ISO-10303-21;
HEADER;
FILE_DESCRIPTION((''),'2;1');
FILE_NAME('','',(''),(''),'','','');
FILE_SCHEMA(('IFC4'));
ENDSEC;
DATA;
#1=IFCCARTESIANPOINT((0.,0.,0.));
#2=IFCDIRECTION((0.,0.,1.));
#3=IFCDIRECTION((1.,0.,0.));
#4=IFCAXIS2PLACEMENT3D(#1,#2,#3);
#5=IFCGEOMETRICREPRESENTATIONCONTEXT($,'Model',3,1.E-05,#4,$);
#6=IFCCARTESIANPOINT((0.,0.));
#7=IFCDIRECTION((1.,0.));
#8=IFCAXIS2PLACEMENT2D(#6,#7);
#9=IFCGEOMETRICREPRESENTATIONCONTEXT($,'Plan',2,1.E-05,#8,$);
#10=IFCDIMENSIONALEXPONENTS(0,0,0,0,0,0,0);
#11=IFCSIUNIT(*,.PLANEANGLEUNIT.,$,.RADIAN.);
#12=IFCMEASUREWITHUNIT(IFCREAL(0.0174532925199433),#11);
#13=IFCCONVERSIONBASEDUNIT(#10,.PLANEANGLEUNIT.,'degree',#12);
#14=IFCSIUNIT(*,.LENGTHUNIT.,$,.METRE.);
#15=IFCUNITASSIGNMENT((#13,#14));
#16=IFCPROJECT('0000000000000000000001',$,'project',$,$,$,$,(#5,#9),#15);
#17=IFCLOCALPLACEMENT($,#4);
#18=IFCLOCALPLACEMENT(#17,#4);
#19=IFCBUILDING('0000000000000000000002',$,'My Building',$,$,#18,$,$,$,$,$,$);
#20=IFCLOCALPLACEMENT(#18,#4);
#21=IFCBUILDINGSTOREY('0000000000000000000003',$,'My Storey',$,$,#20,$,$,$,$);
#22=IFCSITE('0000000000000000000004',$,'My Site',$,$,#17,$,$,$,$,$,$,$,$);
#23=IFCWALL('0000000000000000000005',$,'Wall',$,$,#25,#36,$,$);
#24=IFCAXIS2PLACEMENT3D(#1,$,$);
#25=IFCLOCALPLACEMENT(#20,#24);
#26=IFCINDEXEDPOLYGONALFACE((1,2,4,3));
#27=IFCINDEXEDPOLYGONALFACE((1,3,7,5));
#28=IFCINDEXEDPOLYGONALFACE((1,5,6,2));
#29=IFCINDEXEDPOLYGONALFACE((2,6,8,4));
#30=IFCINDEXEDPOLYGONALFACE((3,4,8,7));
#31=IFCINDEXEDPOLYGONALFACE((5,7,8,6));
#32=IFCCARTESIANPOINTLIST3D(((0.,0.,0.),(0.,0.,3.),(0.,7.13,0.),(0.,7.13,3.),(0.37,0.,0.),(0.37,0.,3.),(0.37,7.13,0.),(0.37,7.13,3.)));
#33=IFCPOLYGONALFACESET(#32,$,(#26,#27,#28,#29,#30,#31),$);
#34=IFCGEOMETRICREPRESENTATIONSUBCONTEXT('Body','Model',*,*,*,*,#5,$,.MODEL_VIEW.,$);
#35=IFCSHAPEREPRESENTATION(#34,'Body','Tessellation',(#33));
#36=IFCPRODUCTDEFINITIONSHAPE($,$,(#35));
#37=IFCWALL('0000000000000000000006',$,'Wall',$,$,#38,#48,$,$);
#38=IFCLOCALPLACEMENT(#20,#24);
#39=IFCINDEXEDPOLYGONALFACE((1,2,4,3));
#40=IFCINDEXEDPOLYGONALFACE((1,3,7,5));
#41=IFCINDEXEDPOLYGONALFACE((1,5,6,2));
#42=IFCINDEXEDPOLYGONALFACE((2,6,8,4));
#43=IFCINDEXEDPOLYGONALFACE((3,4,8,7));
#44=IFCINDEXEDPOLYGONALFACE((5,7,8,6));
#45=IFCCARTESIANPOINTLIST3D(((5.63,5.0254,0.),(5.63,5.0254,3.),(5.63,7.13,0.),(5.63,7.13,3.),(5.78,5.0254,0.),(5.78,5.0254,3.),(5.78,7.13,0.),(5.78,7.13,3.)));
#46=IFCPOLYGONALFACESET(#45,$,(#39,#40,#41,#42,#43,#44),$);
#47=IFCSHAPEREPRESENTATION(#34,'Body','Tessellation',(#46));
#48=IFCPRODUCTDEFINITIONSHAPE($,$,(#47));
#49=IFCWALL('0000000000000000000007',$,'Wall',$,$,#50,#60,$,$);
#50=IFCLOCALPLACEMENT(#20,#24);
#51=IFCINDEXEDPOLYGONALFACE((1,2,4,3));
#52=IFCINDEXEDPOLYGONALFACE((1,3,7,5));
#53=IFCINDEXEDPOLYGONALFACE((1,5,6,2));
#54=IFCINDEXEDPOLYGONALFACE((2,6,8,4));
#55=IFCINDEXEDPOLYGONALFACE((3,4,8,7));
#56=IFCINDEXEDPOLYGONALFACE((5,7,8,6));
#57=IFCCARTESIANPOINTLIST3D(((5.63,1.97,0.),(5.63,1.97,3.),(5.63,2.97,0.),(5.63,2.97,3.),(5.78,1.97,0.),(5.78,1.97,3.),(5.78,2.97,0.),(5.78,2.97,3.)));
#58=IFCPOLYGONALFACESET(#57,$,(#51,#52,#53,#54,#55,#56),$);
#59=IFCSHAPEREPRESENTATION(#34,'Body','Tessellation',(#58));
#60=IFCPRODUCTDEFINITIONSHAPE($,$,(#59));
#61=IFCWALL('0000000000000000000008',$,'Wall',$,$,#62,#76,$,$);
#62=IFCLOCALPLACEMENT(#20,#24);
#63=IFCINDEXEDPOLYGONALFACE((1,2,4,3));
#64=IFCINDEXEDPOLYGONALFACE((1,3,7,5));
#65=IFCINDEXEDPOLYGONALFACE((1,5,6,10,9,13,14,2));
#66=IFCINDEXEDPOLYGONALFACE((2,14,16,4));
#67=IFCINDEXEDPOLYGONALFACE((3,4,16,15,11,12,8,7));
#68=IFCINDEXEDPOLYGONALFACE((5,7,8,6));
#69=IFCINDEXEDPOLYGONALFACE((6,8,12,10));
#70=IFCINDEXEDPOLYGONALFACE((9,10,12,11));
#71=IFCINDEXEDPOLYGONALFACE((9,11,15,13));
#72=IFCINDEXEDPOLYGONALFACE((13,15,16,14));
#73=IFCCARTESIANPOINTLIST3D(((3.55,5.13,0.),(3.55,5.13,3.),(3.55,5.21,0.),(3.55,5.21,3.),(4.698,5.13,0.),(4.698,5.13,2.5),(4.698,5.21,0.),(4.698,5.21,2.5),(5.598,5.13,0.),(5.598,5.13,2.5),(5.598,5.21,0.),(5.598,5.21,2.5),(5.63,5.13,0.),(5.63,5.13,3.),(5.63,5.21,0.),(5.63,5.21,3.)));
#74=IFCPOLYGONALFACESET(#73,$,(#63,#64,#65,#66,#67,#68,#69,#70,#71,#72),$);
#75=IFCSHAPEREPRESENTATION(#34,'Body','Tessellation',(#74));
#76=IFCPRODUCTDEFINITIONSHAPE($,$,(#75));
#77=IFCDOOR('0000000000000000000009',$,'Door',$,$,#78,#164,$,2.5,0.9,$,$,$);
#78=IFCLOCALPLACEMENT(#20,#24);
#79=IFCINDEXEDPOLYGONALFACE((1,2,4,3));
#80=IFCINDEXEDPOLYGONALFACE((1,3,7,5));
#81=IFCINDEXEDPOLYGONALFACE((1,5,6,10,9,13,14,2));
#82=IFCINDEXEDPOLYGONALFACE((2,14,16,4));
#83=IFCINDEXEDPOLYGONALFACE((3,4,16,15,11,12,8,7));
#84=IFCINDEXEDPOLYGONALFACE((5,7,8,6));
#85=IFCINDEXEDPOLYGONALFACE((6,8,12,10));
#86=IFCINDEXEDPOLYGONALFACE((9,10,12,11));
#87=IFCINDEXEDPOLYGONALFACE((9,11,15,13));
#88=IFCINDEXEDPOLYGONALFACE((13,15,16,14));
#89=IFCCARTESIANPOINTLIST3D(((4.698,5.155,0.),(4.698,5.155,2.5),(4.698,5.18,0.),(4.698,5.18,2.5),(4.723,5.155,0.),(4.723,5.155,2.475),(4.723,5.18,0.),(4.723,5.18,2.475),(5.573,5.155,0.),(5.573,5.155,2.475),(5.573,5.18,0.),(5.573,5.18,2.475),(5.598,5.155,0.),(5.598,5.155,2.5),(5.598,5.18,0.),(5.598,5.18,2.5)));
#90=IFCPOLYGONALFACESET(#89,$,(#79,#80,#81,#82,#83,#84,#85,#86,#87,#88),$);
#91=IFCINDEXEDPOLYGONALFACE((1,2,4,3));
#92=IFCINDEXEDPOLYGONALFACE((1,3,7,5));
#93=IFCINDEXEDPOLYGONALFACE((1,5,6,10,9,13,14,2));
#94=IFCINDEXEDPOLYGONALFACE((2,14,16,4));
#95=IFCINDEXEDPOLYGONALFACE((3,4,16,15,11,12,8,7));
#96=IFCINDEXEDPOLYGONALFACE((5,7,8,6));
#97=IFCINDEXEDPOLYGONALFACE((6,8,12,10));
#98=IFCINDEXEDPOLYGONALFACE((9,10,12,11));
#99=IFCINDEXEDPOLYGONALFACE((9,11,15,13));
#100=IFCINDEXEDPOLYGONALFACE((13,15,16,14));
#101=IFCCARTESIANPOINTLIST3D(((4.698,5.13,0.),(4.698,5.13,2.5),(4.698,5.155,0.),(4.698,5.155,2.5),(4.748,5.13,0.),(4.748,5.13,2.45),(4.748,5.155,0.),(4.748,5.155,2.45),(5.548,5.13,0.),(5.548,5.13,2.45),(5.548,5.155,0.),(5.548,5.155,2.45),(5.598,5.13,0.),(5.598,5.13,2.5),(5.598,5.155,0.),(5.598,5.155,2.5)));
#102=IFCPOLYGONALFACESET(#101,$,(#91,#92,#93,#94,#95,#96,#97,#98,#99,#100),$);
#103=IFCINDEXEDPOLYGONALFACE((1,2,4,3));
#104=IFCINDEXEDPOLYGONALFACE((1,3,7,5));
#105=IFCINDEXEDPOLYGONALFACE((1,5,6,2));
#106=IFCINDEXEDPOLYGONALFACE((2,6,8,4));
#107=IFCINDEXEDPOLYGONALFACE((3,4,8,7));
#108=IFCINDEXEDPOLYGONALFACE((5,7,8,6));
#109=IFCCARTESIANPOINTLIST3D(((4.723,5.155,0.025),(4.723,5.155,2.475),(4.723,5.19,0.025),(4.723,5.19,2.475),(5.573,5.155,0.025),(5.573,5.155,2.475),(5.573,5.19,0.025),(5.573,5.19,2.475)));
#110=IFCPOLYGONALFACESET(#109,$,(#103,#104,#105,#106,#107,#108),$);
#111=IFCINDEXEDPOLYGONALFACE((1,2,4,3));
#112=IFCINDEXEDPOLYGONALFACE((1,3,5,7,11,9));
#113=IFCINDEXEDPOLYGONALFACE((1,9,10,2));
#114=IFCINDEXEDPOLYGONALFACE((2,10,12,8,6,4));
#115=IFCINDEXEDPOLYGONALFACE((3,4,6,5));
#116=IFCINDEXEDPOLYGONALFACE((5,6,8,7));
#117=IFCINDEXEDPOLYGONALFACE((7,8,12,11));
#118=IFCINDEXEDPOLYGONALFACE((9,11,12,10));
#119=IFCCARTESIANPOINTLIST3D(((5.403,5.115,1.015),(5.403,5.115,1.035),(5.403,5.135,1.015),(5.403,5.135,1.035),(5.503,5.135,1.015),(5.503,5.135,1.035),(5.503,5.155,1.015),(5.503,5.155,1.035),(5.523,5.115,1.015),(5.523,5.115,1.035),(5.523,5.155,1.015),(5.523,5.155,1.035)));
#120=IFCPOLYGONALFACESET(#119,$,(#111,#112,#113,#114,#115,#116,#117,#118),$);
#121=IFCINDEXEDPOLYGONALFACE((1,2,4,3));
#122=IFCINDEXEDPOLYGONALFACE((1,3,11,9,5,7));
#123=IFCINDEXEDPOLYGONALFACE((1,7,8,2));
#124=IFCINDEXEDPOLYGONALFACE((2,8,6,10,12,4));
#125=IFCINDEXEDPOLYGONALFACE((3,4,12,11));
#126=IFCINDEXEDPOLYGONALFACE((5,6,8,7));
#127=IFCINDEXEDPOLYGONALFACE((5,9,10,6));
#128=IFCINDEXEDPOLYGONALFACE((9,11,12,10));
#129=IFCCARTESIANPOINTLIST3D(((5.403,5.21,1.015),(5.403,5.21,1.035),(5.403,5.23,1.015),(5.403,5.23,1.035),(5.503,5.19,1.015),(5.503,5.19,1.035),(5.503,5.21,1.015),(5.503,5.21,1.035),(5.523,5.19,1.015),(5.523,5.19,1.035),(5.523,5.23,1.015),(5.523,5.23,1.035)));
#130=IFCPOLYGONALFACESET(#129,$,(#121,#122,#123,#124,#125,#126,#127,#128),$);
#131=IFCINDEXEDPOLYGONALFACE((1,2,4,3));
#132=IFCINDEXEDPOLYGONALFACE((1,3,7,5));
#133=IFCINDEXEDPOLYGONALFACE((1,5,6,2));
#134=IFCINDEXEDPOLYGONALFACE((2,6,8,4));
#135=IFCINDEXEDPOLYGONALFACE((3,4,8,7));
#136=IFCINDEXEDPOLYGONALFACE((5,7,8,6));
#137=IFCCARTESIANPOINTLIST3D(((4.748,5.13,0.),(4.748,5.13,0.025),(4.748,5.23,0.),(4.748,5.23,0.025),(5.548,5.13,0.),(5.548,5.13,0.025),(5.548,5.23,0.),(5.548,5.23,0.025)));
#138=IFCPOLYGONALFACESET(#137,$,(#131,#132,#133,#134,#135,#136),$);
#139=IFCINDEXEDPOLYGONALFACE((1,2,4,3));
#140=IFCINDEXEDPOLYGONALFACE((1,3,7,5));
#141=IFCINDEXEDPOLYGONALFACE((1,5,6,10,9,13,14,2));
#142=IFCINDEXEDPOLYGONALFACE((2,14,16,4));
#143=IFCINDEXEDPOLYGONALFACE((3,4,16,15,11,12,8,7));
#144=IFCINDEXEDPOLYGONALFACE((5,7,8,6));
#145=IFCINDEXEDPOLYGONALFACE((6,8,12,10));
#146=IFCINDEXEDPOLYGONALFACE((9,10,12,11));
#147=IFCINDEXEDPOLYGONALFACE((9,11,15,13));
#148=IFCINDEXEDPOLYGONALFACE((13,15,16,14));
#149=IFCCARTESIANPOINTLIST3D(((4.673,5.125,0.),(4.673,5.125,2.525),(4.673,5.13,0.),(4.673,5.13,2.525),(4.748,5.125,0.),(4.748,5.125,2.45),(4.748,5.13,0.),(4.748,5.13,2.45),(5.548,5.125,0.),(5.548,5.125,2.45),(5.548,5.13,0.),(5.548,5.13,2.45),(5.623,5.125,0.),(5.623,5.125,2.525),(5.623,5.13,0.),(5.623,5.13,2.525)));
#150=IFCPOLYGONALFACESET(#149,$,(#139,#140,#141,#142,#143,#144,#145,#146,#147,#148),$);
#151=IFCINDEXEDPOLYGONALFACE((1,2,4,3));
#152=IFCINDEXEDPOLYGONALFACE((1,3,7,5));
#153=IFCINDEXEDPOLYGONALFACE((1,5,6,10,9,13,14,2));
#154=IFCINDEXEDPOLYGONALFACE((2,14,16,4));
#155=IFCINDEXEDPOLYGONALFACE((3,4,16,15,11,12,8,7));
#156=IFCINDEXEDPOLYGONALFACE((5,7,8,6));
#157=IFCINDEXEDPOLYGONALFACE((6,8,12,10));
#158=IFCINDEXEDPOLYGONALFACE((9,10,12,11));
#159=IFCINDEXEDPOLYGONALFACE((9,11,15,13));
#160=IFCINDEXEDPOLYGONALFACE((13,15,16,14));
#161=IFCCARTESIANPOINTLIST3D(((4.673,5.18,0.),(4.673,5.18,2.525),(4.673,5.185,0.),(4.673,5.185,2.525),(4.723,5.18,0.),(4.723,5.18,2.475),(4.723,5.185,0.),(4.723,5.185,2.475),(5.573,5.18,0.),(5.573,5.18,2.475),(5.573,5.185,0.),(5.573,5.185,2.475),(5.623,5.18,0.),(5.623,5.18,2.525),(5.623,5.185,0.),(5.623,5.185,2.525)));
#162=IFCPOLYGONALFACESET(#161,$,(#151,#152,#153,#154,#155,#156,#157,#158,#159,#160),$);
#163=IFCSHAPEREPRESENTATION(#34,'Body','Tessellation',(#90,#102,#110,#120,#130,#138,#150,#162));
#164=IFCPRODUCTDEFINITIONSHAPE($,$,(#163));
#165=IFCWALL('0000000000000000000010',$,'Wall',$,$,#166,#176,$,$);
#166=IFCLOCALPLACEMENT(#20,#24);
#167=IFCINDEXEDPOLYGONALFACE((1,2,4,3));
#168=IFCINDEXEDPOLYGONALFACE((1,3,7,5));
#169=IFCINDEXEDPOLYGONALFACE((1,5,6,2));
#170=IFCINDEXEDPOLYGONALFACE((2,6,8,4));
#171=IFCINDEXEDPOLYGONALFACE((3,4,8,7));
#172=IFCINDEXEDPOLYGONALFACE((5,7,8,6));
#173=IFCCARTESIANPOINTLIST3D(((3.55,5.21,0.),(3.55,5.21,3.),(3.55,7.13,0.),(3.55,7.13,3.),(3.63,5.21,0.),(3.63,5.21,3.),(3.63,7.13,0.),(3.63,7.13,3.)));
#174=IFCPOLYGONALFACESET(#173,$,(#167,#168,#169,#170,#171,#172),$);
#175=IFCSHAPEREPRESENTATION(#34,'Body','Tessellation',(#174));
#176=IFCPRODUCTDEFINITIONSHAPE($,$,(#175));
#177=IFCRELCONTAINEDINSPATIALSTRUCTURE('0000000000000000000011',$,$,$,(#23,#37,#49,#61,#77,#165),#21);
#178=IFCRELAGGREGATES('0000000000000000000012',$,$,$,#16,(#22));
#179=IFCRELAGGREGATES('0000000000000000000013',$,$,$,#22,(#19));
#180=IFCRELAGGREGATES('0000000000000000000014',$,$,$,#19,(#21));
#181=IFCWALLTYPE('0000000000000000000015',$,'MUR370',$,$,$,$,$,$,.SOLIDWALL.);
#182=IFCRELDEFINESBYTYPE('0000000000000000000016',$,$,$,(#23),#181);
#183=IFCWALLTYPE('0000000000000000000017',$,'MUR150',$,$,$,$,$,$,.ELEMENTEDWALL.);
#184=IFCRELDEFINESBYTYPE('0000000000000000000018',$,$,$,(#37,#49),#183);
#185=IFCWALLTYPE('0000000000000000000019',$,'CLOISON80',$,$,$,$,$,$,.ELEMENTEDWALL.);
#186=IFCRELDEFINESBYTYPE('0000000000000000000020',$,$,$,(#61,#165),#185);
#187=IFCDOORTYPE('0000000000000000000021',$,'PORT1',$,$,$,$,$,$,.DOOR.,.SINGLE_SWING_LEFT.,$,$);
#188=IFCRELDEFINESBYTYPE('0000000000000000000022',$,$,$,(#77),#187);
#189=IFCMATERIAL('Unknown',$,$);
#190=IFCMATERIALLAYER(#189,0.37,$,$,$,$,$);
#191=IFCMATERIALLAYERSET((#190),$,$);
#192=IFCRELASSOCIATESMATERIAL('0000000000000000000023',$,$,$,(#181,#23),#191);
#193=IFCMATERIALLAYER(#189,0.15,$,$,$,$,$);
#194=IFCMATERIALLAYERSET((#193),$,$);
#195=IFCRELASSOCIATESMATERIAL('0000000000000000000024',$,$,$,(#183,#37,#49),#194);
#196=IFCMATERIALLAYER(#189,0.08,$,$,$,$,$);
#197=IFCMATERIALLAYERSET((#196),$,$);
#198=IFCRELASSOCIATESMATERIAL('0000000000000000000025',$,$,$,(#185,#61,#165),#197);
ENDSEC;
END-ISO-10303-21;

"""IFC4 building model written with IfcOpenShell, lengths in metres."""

from ifc_helpers import new_model, entity, si_unit, converted_unit, frame, origin_with_axes, origin_2d_with_axis, place, context, subcontext, project, spatial, line, indexed_curve, outline, extrude, shape, source, transform, mapped, material, layer, layer_set, layer_usage, type_object, type_shapes, element, fill, save


model = new_model("IFC4")

# Units and contexts
model_context = context("Model", 3, precision=1e-05, world=origin_with_axes())
plan_context = context("Plan", 2, precision=1e-05, world=origin_2d_with_axis())
body_context_1 = subcontext(model_context, "Body", "Model", "MODEL_VIEW")
body_context_2 = subcontext(plan_context, "Body", "Plan", "PLAN_VIEW")
ifc_project = project(units=[converted_unit("PLANEANGLEUNIT", "degree", entity("IfcReal", 0.0174532925199433), si_unit("PLANEANGLEUNIT", "RADIAN"), dimensions=[0, 0, 0, 0, 0, 0, 0]), si_unit("LENGTHUNIT", "METRE")], contexts=[model_context, plan_context])

# Site, building, storey
site_placement = place(None, origin_with_axes())
site = spatial("IfcSite", under=ifc_project, at=site_placement, Name="My Site")
building_placement = place(site_placement, origin_with_axes())
building = spatial("IfcBuilding", under=site, at=building_placement, Name="My Building")
storey_placement = place(building_placement, origin_with_axes())
storey = spatial("IfcBuildingStorey", under=building, at=storey_placement, Name="My Storey")

# Shared definitions
ifc_material = material(Name="Unknown")

# Shared definitions
ifc_layer_1 = layer(ifc_material, 0.37)
ifc_layer_set_1 = layer_set([ifc_layer_1])
wall_type_1 = type_object("IfcWallType", Name="MUR370", PredefinedType="SOLIDWALL", material=ifc_layer_set_1)

# Shared definitions
shared_shape_1 = source(origin_with_axes(), body_context_1, "Body", "SweptSolid", [
    extrude(outline(indexed_curve([(0.0, 0.0), (0.9, 0.0), (0.9, 2.5), (0.0, 2.5)], segments=[line(1, 2, 3, 4, 1)])), frame((0.0, -0.6, 0.0), z_axis=(0.0, -1.0, 0.0), x_axis=(1.0, 0.0, 0.0)), (0.0, 0.0, -1.0), 1.2),
])
door_type_1 = type_object("IfcDoorType", Name="PORT1", OperationType="SINGLE_SWING_LEFT", PredefinedType="DOOR")
shared_shape_2 = source(origin_with_axes(), body_context_1, "Body", "SweptSolid", [
    extrude(outline(indexed_curve([(0.0, 0.0), (0.0, 2.5), (0.9, 2.5), (0.9, 0.0), (0.875, 0.0), (0.875, 2.475), (0.025, 2.475), (0.025, 0.0)], segments=[line(1, 2, 3, 4, 5, 6, 7, 8, 1)])), frame((0.0, 0.025, 0.0), z_axis=(0.0, -1.0, 0.0), x_axis=(1.0, 0.0, 0.0)), (0.0, 0.0, -1.0), 0.025),
    extrude(outline(indexed_curve([(0.0, 0.0), (0.0, 2.5), (0.9, 2.5), (0.9, 0.0), (0.85, 0.0), (0.85, 2.45), (0.05, 2.45), (0.05, 0.0)], segments=[line(1, 2, 3, 4, 5, 6, 7, 8, 1)])), frame((0.0, 0.0, 0.0), z_axis=(0.0, -1.0, 0.0), x_axis=(1.0, 0.0, 0.0)), (0.0, 0.0, -1.0), 0.025),
    extrude(outline(indexed_curve([(0.0, 0.0), (0.85, 0.0), (0.85, 0.035), (0.0, 0.035)], segments=[line(1, 2, 3, 4, 1)])), frame((0.025, 0.025, 0.025), z_axis=(0.0, 0.0, 1.0), x_axis=(1.0, 0.0, 0.0)), (0.0, 0.0, 1.0), 2.45),
    extrude(outline(indexed_curve([(0.0, 0.0), (0.0, -0.04), (-0.12, -0.04), (-0.12, -0.02), (-0.02, -0.02), (-0.02, 0.0)], segments=[line(1, 2, 3, 4, 5, 6, 1)])), frame((0.825, 0.025, 1.015), z_axis=(0.0, 0.0, 1.0), x_axis=(1.0, 0.0, 0.0)), (0.0, 0.0, 1.0), 0.02),
    extrude(outline(indexed_curve([(0.0, 0.0), (0.0, 0.04), (-0.12, 0.04), (-0.12, 0.02), (-0.02, 0.02), (-0.02, 0.0)], segments=[line(1, 2, 3, 4, 5, 6, 1)])), frame((0.825, 0.06, 1.015), z_axis=(0.0, 0.0, 1.0), x_axis=(1.0, 0.0, 0.0)), (0.0, 0.0, 1.0), 0.02),
    extrude(outline(indexed_curve([(0.0, 0.0), (0.8, 0.0), (0.8, 0.1), (0.0, 0.1)], segments=[line(1, 2, 3, 4, 1)])), frame((0.05, 0.0, 0.0), z_axis=(0.0, 0.0, 1.0), x_axis=(1.0, 0.0, 0.0)), (0.0, 0.0, 1.0), 0.025),
    extrude(outline(indexed_curve([(0.0, 0.0), (0.0, 2.525), (0.95, 2.525), (0.95, 0.0), (0.875, 0.0), (0.875, 2.45), (0.075, 2.45), (0.075, 0.0)], segments=[line(1, 2, 3, 4, 5, 6, 7, 8, 1)])), frame((-0.025, -0.005, 0.0), z_axis=(0.0, -1.0, 0.0), x_axis=(1.0, 0.0, 0.0)), (0.0, 0.0, -1.0), 0.005),
    extrude(outline(indexed_curve([(0.0, 0.0), (0.0, 2.525), (0.95, 2.525), (0.95, 0.0), (0.9, 0.0), (0.9, 2.475), (0.05, 2.475), (0.05, 0.0)], segments=[line(1, 2, 3, 4, 5, 6, 7, 8, 1)])), frame((-0.025, 0.05, 0.0), z_axis=(0.0, -1.0, 0.0), x_axis=(1.0, 0.0, 0.0)), (0.0, 0.0, -1.0), 0.005),
])
shared_shape_3 = source(origin_with_axes(), body_context_2, "Body", "Curve2D", [
    entity("IfcIndexedPolyCurve", entity("IfcCartesianPointList2D", [[0.0, 0.0], [0.0, 0.05], [0.025, 0.05], [0.025, 0.025], [0.05, 0.025], [0.05, 0.0]]), [entity("IfcLineIndex", [1, 2, 3, 4, 5, 6, 1])]),
    entity("IfcIndexedPolyCurve", entity("IfcCartesianPointList2D", [[0.9, 0.0], [0.9, 0.05], [0.875, 0.05], [0.875, 0.025], [0.85, 0.025], [0.85, 0.0]]), [entity("IfcLineIndex", [1, 2, 3, 4, 5, 6, 1])]),
    entity("IfcTrimmedCurve", entity("IfcEllipse", entity("IfcAxis2Placement2D", entity("IfcCartesianPoint", [0.06, 0.05]), entity("IfcDirection", [1.0, 0.0])), 0.815, 0.85), [entity("IfcCartesianPoint", [0.875, 0.05])], [entity("IfcCartesianPoint", [0.06, 0.9])], True, "CARTESIAN"),
    entity("IfcIndexedPolyCurve", entity("IfcCartesianPointList2D", [[0.025, 0.05], [0.06, 0.05], [0.06, 0.9], [0.025, 0.9]]), [entity("IfcLineIndex", [1, 2, 3, 4, 1])]),
])
type_shapes(door_type_1, [shared_shape_2, shared_shape_3])

# Walls
ifc_layer_usage_1 = layer_usage(ifc_layer_set_1, "AXIS2", "POSITIVE", 0.0)
wall_1_placement = place(storey_placement, frame((0.0, 7.13, 0.0), z_axis=(0.0, 0.0, 1.0), x_axis=(-0.000001, -1.0, 0.0)))
element("IfcWall", 1, at=wall_1_placement, inside=storey, type_object=wall_type_1, material=ifc_layer_usage_1, Name="Wall", context=body_context_1, shape_type="SweptSolid", body=[
    extrude(outline(indexed_curve([(0.0, 0.0), (0.0, 0.37), (7.13, 0.37), (7.13, 0.0), (0.0, 0.0)], self_intersect=False)), origin_with_axes(), (0.0, 0.0, 1.0), 3.0),
])
ifc_layer_2 = layer(ifc_material, 0.15)
ifc_layer_set_2 = layer_set([ifc_layer_2])
ifc_layer_usage_2 = layer_usage(ifc_layer_set_2, "AXIS2", "POSITIVE", 0.0)
wall_type_2 = type_object("IfcWallType", Name="MUR150", PredefinedType="ELEMENTEDWALL", material=ifc_layer_set_2)
wall_2_placement = place(storey_placement, frame((5.63, 7.13, 0.0), z_axis=(0.0, 0.0, 1.0), x_axis=(0.0, -1.0, 0.0)))
element("IfcWall", 2, at=wall_2_placement, inside=storey, type_object=wall_type_2, material=ifc_layer_usage_2, Name="Wall", context=body_context_1, shape_type="SweptSolid", body=[
    extrude(outline(indexed_curve([(0.0, 0.0), (0.0, 0.15), (2.1046, 0.15), (2.1046, 0.0), (0.0, 0.0)], self_intersect=False)), origin_with_axes(), (0.0, 0.0, 1.0), 3.0),
])
ifc_layer_usage_3 = layer_usage(ifc_layer_set_2, "AXIS2", "POSITIVE", 0.0)
wall_3_placement = place(storey_placement, frame((5.63, 2.97, 0.0), z_axis=(0.0, 0.0, 1.0), x_axis=(0.0, -1.0, 0.0)))
element("IfcWall", 3, at=wall_3_placement, inside=storey, type_object=wall_type_2, material=ifc_layer_usage_3, Name="Wall", context=body_context_1, shape_type="SweptSolid", body=[
    extrude(outline(indexed_curve([(0.0, 0.0), (0.0, 0.15), (1.0, 0.15), (1.0, 0.0), (0.0, 0.0)], self_intersect=False)), origin_with_axes(), (0.0, 0.0, 1.0), 3.0),
])

# Wall, opening, door
ifc_layer_3 = layer(ifc_material, 0.08)
ifc_layer_set_3 = layer_set([ifc_layer_3])
ifc_layer_usage_4 = layer_usage(ifc_layer_set_3, "AXIS2", "POSITIVE", 0.0)
wall_type_3 = type_object("IfcWallType", Name="CLOISON80", PredefinedType="ELEMENTEDWALL", material=ifc_layer_set_3)
wall_4_placement = place(storey_placement, frame((3.55, 5.13, 0.0), z_axis=(0.0, 0.0, 1.0), x_axis=(1.0, 0.0, 0.0)))
wall_4 = element("IfcWall", 4, at=wall_4_placement, inside=storey, type_object=wall_type_3, material=ifc_layer_usage_4, Name="Wall", context=body_context_1, shape_type="SweptSolid", body=[
    extrude(outline(indexed_curve([(0.0, 0.0), (0.0, 0.08), (2.08, 0.08), (2.08, 0.0), (0.0, 0.0)], self_intersect=False)), origin_with_axes(), (0.0, 0.0, 1.0), 3.0),
])
opening_1_placement = place(wall_4_placement, frame((1.148, 0.0, 0.0), z_axis=(0.0, 0.0, 1.0), x_axis=(1.0, 0.0, 0.0)))
opening_1 = element("IfcOpeningElement", 5, at=opening_1_placement, cuts=wall_4, PredefinedType="OPENING", context=body_context_1, shape_type="MappedRepresentation", body=[
    mapped(shared_shape_1, transform((0.0, 0.0, 0.0), x_axis=(1.0, 0.0, 0.0), y_axis=(0.0, 1.0, 0.0), z_axis=(0.0, 0.0, 1.0), scale=1.0)),
])
door_1_placement = place(opening_1_placement, frame((0.0, 0.0, 0.0), z_axis=(0.0, 0.0, 1.0), x_axis=(1.0, 0.0, 0.0)))
door_1 = element("IfcDoor", 6, at=door_1_placement, inside=storey, type_object=door_type_1, Name="Door", OverallHeight=2.5, OverallWidth=0.9, shapes=[
    shape(body_context_1, "Body", "MappedRepresentation", [mapped(shared_shape_2, transform((0.0, 0.0, 0.0), x_axis=(1.0, 0.0, 0.0), y_axis=(0.0, 1.0, 0.0), z_axis=(0.0, 0.0, 1.0), scale=1.0))]),
    shape(body_context_2, "Body", "MappedRepresentation", [mapped(shared_shape_3, transform((0.0, 0.0, 0.0), x_axis=(1.0, 0.0, 0.0), y_axis=(0.0, 1.0, 0.0), z_axis=(0.0, 0.0, 1.0), scale=1.0))]),
])
fill(opening_1, door_1)

# Wall
ifc_layer_usage_5 = layer_usage(ifc_layer_set_3, "AXIS2", "POSITIVE", 0.0)
wall_5_placement = place(storey_placement, frame((3.63, 5.21, 0.0), z_axis=(0.0, 0.0, 1.0), x_axis=(0.0, 1.0, 0.0)))
element("IfcWall", 7, at=wall_5_placement, inside=storey, type_object=wall_type_3, material=ifc_layer_usage_5, Name="Wall", context=body_context_1, shape_type="SweptSolid", body=[
    extrude(outline(indexed_curve([(0.0, 0.0), (0.0, 0.08), (1.92, 0.08), (1.92, 0.0), (0.0, 0.0)], self_intersect=False)), origin_with_axes(), (0.0, 0.0, 1.0), 3.0),
])

save(model, "model.ifc")
